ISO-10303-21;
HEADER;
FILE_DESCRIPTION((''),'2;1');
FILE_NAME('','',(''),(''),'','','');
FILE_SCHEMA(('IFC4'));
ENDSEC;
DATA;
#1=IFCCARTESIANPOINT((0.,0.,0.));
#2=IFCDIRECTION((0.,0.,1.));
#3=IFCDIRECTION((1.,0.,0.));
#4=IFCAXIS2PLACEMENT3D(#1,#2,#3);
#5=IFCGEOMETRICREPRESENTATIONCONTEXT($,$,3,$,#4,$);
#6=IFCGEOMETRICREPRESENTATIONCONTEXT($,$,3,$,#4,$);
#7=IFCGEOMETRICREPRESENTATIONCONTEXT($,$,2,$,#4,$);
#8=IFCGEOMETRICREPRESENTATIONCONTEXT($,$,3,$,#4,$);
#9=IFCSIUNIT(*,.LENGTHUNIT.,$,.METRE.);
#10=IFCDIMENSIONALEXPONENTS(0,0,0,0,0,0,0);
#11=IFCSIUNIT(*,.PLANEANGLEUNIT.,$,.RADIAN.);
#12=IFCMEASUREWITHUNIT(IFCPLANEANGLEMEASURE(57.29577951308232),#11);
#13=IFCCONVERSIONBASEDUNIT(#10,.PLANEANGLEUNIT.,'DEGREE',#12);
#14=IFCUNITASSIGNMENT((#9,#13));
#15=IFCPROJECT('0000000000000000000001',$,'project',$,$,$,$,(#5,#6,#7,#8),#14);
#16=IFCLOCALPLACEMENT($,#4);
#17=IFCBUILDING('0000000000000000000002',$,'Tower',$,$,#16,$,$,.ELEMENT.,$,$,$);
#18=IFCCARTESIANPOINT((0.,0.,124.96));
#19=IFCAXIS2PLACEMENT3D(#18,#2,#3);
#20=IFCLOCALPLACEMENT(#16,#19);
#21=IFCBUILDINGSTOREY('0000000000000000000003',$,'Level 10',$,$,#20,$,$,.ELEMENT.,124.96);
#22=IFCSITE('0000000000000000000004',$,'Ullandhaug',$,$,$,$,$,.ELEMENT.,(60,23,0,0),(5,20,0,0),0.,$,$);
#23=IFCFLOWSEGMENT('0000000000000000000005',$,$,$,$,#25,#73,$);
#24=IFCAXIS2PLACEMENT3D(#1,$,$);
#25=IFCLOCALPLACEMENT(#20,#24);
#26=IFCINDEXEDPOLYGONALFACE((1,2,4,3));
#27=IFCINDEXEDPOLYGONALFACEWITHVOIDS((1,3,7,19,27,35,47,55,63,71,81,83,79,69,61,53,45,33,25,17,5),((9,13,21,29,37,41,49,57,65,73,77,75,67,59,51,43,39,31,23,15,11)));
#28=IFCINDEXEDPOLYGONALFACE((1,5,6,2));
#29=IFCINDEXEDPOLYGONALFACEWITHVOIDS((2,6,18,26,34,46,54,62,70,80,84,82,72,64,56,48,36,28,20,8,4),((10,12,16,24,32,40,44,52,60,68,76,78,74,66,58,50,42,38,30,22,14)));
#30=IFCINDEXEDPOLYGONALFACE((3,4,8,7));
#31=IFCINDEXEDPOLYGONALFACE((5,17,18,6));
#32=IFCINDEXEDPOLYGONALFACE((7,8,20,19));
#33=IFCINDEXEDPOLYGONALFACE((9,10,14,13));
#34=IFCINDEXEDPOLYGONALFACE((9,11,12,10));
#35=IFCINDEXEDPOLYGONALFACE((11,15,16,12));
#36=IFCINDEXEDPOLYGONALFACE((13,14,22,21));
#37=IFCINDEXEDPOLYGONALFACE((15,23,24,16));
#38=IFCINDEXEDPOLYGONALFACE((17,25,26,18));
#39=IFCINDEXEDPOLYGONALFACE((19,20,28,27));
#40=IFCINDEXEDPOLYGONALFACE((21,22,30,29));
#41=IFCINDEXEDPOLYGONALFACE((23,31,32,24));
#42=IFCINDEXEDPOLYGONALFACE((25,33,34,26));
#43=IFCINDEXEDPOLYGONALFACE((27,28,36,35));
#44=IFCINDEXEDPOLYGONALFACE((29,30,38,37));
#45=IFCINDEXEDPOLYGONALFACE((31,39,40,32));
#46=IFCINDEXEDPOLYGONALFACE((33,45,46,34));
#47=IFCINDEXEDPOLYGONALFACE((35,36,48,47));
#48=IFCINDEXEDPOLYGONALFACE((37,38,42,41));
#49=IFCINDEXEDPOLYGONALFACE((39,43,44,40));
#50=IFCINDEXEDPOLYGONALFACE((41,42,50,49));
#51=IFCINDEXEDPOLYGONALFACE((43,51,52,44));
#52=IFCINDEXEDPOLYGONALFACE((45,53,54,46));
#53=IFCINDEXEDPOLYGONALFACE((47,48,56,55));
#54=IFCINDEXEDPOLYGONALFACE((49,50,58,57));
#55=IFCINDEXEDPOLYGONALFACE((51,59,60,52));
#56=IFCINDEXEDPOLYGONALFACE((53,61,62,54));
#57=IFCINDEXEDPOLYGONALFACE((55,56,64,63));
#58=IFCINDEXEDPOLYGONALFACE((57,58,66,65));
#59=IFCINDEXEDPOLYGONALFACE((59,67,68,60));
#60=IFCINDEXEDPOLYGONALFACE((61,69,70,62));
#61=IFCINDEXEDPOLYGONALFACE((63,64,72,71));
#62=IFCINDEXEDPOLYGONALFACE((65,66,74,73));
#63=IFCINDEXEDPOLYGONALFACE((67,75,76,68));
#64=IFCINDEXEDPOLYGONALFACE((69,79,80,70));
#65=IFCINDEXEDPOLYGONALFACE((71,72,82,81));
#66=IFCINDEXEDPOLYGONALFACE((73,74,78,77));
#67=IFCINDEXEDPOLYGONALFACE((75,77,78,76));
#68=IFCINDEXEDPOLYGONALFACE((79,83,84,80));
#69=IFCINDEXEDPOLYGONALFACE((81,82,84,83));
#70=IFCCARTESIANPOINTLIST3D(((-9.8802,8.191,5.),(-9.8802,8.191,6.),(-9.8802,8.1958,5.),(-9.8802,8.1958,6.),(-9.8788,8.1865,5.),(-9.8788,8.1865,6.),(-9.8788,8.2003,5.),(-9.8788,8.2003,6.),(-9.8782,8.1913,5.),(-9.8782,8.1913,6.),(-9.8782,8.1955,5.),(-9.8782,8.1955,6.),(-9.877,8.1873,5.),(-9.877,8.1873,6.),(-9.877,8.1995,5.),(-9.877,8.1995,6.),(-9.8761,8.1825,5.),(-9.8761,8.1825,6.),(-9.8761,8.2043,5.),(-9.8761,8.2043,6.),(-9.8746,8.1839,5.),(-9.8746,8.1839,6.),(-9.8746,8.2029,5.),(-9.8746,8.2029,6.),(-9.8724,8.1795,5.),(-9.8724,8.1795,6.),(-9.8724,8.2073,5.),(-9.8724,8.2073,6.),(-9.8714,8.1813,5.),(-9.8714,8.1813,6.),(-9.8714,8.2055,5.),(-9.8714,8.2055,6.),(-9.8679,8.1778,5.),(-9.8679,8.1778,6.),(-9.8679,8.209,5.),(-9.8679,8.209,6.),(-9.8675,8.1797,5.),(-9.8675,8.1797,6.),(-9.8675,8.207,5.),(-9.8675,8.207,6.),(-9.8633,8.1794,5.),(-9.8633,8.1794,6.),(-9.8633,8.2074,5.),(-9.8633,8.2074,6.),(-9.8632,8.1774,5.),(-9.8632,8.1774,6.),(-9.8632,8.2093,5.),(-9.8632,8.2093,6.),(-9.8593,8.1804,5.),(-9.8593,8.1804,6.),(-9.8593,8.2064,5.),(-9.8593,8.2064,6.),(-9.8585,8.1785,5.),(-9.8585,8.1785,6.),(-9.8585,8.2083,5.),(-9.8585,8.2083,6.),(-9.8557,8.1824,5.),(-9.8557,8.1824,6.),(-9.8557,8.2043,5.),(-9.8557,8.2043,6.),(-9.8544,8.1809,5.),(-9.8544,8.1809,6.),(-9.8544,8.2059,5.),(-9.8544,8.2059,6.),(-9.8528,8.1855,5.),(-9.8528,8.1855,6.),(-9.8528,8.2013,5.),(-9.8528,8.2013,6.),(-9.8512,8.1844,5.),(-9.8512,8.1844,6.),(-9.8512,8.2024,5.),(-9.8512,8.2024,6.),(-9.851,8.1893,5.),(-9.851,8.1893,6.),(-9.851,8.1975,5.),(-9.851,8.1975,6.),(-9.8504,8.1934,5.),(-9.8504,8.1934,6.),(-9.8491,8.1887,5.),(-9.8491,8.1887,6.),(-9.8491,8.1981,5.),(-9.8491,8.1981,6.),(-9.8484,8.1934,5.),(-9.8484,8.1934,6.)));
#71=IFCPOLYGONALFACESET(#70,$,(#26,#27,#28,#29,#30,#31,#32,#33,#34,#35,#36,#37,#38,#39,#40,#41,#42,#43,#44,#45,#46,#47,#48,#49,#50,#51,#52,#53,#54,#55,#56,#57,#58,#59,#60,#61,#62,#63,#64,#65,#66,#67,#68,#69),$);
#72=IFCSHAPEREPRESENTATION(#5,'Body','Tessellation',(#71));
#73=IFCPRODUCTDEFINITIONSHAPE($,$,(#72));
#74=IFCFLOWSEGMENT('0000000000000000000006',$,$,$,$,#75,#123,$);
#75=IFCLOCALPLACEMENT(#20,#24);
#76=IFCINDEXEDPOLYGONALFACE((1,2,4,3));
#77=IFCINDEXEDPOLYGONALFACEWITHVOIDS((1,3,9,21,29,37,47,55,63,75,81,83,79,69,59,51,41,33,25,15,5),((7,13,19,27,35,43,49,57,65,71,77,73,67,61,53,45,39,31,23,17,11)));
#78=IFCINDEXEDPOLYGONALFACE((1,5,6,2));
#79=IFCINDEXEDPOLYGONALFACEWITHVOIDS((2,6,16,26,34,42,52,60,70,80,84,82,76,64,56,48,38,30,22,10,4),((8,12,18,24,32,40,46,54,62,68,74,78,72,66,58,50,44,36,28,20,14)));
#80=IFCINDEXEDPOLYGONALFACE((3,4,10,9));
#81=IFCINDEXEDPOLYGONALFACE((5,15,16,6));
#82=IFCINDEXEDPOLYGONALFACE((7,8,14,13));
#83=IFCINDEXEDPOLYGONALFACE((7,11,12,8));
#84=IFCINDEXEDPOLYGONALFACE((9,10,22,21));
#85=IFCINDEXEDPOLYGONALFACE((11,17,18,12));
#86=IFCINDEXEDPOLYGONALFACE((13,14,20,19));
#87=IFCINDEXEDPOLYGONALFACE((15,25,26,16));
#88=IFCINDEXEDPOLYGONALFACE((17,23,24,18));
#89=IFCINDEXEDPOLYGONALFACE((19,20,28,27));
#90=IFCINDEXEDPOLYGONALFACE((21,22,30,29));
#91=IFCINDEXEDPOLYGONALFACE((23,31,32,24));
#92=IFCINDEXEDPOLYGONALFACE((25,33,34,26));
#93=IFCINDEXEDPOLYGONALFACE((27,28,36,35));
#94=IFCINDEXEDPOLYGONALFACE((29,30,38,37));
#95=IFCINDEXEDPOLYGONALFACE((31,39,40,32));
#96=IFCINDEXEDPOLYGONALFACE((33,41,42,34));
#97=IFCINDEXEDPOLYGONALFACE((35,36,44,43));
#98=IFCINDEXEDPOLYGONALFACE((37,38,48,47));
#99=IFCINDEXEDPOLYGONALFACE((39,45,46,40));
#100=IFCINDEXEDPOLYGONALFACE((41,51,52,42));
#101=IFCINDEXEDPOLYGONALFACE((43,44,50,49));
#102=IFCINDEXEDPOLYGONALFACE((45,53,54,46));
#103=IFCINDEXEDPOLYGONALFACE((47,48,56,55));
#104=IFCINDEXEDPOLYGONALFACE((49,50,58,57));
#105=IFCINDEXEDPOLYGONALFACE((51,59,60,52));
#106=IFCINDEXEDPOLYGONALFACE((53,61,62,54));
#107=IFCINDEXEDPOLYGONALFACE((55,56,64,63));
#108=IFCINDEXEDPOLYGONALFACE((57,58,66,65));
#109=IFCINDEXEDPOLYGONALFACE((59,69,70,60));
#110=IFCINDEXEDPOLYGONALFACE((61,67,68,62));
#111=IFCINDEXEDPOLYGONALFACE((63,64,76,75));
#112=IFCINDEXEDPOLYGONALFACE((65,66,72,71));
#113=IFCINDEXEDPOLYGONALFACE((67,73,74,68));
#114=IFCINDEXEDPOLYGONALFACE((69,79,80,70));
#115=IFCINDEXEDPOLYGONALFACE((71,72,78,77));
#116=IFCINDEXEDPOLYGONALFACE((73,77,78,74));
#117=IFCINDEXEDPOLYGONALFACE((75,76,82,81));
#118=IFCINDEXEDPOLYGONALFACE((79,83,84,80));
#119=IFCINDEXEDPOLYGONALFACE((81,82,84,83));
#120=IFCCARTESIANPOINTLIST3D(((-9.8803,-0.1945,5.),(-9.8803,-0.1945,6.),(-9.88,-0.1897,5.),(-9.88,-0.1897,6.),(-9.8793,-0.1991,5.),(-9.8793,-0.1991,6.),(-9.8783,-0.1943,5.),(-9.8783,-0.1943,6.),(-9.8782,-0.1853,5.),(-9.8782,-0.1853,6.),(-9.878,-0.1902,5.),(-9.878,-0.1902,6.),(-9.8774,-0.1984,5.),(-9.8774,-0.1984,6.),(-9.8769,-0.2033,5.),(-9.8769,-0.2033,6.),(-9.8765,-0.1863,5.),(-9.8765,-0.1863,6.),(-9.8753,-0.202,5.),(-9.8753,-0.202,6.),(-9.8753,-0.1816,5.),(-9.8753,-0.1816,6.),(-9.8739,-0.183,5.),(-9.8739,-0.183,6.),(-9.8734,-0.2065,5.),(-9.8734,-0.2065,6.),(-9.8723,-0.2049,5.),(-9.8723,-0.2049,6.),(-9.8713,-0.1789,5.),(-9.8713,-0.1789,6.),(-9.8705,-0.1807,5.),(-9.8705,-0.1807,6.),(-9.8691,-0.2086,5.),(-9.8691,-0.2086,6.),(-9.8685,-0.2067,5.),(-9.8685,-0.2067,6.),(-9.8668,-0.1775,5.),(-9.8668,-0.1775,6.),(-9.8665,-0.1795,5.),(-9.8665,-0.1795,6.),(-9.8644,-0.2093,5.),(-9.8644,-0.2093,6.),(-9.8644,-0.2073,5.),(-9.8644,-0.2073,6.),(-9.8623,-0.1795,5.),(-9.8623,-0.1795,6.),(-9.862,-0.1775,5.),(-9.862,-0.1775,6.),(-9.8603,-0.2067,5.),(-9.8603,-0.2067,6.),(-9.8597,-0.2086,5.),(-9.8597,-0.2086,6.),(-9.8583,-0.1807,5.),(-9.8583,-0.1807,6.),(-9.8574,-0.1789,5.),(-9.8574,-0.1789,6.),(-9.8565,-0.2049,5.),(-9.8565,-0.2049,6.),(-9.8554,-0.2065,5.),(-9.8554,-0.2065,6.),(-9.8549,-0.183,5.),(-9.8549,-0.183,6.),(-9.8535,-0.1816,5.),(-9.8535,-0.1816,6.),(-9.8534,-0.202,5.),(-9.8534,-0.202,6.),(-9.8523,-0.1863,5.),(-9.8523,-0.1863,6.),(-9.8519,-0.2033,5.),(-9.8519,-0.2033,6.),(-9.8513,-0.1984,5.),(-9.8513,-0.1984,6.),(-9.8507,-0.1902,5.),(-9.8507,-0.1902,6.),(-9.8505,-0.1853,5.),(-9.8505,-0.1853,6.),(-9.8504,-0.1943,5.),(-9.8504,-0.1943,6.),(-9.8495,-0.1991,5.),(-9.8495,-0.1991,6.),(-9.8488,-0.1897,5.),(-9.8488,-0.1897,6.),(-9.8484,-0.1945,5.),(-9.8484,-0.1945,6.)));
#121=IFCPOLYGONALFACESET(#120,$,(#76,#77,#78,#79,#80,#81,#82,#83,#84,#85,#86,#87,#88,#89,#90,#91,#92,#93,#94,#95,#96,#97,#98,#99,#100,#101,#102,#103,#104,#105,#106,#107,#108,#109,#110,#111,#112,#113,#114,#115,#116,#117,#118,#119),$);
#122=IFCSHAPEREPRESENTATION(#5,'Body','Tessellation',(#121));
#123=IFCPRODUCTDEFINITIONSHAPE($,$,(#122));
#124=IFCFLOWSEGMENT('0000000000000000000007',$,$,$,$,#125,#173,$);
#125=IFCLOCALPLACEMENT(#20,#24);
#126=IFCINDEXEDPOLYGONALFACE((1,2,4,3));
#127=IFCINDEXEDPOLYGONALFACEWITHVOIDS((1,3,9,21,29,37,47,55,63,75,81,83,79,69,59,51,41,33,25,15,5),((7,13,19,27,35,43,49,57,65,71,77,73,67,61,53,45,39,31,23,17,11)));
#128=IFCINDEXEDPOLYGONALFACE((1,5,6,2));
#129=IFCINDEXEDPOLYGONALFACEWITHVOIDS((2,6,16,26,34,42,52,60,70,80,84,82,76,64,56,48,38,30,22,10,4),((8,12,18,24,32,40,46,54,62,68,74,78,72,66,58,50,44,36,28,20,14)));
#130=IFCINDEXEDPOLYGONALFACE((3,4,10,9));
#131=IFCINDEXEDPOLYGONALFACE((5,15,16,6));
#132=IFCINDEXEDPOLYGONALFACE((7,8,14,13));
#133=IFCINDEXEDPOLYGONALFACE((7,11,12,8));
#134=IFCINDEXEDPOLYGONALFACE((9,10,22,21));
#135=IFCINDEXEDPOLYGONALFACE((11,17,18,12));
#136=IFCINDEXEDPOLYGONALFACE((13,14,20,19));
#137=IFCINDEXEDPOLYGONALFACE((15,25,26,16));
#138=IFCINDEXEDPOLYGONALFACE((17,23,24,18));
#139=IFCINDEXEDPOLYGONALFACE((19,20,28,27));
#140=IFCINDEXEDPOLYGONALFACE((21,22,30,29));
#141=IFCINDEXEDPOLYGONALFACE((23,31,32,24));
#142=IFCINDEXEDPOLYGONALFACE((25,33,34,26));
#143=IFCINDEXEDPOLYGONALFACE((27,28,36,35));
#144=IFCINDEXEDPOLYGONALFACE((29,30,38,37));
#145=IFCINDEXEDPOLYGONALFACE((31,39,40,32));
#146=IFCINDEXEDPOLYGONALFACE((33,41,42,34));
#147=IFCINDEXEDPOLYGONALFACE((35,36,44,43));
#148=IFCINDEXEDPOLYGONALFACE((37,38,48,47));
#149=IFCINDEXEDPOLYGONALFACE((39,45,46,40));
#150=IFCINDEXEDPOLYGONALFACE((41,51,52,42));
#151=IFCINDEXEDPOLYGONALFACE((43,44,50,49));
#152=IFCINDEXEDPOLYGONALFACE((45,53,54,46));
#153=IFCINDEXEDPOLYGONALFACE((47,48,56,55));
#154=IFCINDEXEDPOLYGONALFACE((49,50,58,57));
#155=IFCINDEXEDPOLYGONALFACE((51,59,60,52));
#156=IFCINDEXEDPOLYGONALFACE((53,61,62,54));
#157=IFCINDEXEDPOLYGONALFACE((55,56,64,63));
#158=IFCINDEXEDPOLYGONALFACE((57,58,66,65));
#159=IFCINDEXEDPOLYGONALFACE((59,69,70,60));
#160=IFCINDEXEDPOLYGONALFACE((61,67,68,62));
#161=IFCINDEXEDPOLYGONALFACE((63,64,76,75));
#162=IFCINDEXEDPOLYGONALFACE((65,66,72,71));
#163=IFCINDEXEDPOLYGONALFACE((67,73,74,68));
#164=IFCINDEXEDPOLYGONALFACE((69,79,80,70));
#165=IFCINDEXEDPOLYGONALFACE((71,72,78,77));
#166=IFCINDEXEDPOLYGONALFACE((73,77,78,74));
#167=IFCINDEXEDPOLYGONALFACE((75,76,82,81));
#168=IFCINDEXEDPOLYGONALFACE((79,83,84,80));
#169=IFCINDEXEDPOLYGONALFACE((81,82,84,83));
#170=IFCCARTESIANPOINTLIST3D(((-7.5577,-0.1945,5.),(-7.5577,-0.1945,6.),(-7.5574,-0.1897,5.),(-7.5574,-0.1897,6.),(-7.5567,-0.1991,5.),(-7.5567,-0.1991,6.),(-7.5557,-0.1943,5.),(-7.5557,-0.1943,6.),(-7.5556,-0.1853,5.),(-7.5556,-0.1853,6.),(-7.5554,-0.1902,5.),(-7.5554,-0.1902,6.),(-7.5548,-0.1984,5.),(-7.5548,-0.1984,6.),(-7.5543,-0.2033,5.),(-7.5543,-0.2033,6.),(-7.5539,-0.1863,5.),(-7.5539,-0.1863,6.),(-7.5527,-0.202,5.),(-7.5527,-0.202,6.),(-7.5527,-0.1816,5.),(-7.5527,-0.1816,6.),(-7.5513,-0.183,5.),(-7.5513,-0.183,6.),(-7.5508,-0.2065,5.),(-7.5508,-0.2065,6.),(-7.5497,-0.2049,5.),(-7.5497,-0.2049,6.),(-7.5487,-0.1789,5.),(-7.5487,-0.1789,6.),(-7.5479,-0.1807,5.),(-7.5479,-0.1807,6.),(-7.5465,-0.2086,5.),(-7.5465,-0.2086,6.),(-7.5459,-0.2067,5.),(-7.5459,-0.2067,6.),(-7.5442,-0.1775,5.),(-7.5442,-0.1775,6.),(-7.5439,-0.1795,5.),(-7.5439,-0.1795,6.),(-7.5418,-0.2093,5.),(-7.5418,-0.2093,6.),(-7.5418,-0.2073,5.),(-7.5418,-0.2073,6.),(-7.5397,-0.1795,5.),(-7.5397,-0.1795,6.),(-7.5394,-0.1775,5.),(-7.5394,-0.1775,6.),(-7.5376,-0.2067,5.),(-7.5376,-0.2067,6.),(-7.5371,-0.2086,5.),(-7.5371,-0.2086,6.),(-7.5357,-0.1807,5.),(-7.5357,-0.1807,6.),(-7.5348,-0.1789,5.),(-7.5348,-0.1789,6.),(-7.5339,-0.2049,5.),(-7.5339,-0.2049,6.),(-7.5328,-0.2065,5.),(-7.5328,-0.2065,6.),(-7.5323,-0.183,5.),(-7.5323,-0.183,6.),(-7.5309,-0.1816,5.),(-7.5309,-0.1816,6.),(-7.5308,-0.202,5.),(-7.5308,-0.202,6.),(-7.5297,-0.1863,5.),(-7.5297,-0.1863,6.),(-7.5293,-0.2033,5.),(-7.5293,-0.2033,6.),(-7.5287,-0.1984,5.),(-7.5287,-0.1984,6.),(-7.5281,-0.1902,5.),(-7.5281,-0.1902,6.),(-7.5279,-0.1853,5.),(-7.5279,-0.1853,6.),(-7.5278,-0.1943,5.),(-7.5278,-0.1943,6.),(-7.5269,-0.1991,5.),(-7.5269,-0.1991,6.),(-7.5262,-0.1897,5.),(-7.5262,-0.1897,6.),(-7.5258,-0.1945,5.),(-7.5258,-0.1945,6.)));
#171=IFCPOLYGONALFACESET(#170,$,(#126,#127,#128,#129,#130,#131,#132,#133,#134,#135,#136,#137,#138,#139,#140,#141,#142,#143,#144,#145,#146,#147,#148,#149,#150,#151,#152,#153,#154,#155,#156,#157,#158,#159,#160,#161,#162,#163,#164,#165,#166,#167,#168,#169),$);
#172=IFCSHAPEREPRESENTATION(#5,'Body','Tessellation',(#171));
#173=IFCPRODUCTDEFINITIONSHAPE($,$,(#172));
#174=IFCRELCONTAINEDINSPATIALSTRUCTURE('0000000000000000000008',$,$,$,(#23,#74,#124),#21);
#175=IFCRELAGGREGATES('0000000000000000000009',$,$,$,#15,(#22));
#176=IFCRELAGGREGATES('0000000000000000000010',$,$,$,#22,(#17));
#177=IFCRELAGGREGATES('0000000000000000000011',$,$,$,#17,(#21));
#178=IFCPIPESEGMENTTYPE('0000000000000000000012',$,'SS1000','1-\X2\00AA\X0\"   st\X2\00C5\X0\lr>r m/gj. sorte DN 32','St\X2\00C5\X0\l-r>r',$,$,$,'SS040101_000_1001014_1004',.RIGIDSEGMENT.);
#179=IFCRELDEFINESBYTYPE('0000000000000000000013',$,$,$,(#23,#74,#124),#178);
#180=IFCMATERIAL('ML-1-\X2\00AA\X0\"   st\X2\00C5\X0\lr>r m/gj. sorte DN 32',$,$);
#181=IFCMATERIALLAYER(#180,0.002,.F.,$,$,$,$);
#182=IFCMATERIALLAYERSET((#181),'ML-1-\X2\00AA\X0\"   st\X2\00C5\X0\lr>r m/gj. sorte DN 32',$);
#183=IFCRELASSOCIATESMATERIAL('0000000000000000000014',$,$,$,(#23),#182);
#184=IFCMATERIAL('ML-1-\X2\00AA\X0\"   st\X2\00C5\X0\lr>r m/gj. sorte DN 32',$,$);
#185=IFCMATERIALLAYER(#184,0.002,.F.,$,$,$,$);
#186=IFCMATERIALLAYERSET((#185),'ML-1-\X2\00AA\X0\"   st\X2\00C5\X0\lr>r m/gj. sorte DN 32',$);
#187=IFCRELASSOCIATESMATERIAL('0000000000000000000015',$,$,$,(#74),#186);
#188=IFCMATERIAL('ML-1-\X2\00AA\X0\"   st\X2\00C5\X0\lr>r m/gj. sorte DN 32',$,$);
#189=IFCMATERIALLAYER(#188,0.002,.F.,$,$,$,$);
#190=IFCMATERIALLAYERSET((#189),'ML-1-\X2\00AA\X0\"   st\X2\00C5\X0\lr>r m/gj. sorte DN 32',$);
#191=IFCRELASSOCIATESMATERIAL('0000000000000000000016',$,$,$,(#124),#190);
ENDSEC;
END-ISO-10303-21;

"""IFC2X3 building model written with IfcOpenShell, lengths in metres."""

from ifc_helpers import new_model, entity, si_unit, converted_unit, frame, origin_with_axes, origin_2d_with_axis, place, context, project, spatial, hollow_circle, extrude, material, layer, layer_set, layer_usage, type_object, element, save


model = new_model("IFC2X3")

# Units and contexts
context_of_model_1 = context(None, 3, world=origin_with_axes())
context_of_model_2 = context(None, 3, world=origin_with_axes())
context_of_model_3 = context(None, 2, world=origin_with_axes())
context_of_model_4 = context(None, 3, world=origin_with_axes())
ifc_project = project(units=[si_unit("LENGTHUNIT", "METRE"), converted_unit("PLANEANGLEUNIT", "DEGREE", entity("IfcPlaneAngleMeasure", 57.29577951308232), si_unit("PLANEANGLEUNIT", "RADIAN"), dimensions=[0, 0, 0, 0, 0, 0, 0])], contexts=[context_of_model_1, context_of_model_2, context_of_model_3, context_of_model_4])

# Site, building, storey
site = spatial("IfcSite", under=ifc_project, Name="Ullandhaug", CompositionType="ELEMENT", RefLatitude=(60, 23, 0, 0), RefLongitude=(5, 20, 0, 0), RefElevation=0.0)
building_placement = place(None, origin_with_axes())
building = spatial("IfcBuilding", under=site, at=building_placement, Name="Tower", CompositionType="ELEMENT")
storey_placement = place(building_placement, frame((0.0, 0.0, 124.96), z_axis=(0.0, 0.0, 1.0), x_axis=(1.0, 0.0, 0.0)))
storey = spatial("IfcBuildingStorey", under=building, at=storey_placement, Name="Level 10", CompositionType="ELEMENT", Elevation=124.96)

# Flow segments
pipe_segment_type_1 = type_object("IfcPipeSegmentType", Name="SS1000", Description="1-ª\"   stÅlr>r m/gj. sorte DN 32", ApplicableOccurrence="StÅl-r>r", ElementType="SS040101_000_1001014_1004", PredefinedType="RIGIDSEGMENT")
ifc_material_1 = material(Name="ML-1-ª\"   stÅlr>r m/gj. sorte DN 32")
ifc_layer_1 = layer(ifc_material_1, 0.002, ventilated=False)
ifc_layer_set_1 = layer_set([ifc_layer_1], Name="ML-1-ª\"   stÅlr>r m/gj. sorte DN 32")
ifc_layer_usage_1 = layer_usage(ifc_layer_set_1, "AXIS2", "POSITIVE", 0.0)
flow_segment_1_placement = place(storey_placement, frame((-9.8644, 8.1934, 5.0), z_axis=(0.0, 0.0, 1.0), x_axis=(1.0, 0.0, 0.0)))
element("IfcFlowSegment", 1, at=flow_segment_1_placement, inside=storey, type_object=pipe_segment_type_1, material=ifc_layer_usage_1, context=context_of_model_1, shape_type="SweptSolid", body=[
    extrude(hollow_circle(Radius=0.016, WallThickness=0.002, at=origin_2d_with_axis()), origin_with_axes(), (0.0, 0.0, 1.0), 1.0),
])
ifc_material_2 = material(Name="ML-1-ª\"   stÅlr>r m/gj. sorte DN 32")
ifc_layer_2 = layer(ifc_material_2, 0.002, ventilated=False)
ifc_layer_set_2 = layer_set([ifc_layer_2], Name="ML-1-ª\"   stÅlr>r m/gj. sorte DN 32")
ifc_layer_usage_2 = layer_usage(ifc_layer_set_2, "AXIS2", "POSITIVE", 0.0)
flow_segment_2_placement = place(storey_placement, frame((-9.8644, -0.1933, 5.0), z_axis=(0.0, 0.0, 1.0), x_axis=(0.0, -1.0, 0.0)))
element("IfcFlowSegment", 2, at=flow_segment_2_placement, inside=storey, type_object=pipe_segment_type_1, material=ifc_layer_usage_2, context=context_of_model_1, shape_type="SweptSolid", body=[
    extrude(hollow_circle(Radius=0.016, WallThickness=0.002, at=origin_2d_with_axis()), origin_with_axes(), (0.0, 0.0, 1.0), 1.0),
])
ifc_material_3 = material(Name="ML-1-ª\"   stÅlr>r m/gj. sorte DN 32")
ifc_layer_3 = layer(ifc_material_3, 0.002, ventilated=False)
ifc_layer_set_3 = layer_set([ifc_layer_3], Name="ML-1-ª\"   stÅlr>r m/gj. sorte DN 32")
ifc_layer_usage_3 = layer_usage(ifc_layer_set_3, "AXIS2", "POSITIVE", 0.0)
flow_segment_3_placement = place(storey_placement, frame((-7.5418, -0.1933, 5.0), z_axis=(0.0, 0.0, 1.0), x_axis=(0.0, -1.0, 0.0)))
element("IfcFlowSegment", 3, at=flow_segment_3_placement, inside=storey, type_object=pipe_segment_type_1, material=ifc_layer_usage_3, context=context_of_model_1, shape_type="SweptSolid", body=[
    extrude(hollow_circle(Radius=0.016, WallThickness=0.002, at=origin_2d_with_axis()), origin_with_axes(), (0.0, 0.0, 1.0), 1.0),
])

save(model, "model.ifc")
